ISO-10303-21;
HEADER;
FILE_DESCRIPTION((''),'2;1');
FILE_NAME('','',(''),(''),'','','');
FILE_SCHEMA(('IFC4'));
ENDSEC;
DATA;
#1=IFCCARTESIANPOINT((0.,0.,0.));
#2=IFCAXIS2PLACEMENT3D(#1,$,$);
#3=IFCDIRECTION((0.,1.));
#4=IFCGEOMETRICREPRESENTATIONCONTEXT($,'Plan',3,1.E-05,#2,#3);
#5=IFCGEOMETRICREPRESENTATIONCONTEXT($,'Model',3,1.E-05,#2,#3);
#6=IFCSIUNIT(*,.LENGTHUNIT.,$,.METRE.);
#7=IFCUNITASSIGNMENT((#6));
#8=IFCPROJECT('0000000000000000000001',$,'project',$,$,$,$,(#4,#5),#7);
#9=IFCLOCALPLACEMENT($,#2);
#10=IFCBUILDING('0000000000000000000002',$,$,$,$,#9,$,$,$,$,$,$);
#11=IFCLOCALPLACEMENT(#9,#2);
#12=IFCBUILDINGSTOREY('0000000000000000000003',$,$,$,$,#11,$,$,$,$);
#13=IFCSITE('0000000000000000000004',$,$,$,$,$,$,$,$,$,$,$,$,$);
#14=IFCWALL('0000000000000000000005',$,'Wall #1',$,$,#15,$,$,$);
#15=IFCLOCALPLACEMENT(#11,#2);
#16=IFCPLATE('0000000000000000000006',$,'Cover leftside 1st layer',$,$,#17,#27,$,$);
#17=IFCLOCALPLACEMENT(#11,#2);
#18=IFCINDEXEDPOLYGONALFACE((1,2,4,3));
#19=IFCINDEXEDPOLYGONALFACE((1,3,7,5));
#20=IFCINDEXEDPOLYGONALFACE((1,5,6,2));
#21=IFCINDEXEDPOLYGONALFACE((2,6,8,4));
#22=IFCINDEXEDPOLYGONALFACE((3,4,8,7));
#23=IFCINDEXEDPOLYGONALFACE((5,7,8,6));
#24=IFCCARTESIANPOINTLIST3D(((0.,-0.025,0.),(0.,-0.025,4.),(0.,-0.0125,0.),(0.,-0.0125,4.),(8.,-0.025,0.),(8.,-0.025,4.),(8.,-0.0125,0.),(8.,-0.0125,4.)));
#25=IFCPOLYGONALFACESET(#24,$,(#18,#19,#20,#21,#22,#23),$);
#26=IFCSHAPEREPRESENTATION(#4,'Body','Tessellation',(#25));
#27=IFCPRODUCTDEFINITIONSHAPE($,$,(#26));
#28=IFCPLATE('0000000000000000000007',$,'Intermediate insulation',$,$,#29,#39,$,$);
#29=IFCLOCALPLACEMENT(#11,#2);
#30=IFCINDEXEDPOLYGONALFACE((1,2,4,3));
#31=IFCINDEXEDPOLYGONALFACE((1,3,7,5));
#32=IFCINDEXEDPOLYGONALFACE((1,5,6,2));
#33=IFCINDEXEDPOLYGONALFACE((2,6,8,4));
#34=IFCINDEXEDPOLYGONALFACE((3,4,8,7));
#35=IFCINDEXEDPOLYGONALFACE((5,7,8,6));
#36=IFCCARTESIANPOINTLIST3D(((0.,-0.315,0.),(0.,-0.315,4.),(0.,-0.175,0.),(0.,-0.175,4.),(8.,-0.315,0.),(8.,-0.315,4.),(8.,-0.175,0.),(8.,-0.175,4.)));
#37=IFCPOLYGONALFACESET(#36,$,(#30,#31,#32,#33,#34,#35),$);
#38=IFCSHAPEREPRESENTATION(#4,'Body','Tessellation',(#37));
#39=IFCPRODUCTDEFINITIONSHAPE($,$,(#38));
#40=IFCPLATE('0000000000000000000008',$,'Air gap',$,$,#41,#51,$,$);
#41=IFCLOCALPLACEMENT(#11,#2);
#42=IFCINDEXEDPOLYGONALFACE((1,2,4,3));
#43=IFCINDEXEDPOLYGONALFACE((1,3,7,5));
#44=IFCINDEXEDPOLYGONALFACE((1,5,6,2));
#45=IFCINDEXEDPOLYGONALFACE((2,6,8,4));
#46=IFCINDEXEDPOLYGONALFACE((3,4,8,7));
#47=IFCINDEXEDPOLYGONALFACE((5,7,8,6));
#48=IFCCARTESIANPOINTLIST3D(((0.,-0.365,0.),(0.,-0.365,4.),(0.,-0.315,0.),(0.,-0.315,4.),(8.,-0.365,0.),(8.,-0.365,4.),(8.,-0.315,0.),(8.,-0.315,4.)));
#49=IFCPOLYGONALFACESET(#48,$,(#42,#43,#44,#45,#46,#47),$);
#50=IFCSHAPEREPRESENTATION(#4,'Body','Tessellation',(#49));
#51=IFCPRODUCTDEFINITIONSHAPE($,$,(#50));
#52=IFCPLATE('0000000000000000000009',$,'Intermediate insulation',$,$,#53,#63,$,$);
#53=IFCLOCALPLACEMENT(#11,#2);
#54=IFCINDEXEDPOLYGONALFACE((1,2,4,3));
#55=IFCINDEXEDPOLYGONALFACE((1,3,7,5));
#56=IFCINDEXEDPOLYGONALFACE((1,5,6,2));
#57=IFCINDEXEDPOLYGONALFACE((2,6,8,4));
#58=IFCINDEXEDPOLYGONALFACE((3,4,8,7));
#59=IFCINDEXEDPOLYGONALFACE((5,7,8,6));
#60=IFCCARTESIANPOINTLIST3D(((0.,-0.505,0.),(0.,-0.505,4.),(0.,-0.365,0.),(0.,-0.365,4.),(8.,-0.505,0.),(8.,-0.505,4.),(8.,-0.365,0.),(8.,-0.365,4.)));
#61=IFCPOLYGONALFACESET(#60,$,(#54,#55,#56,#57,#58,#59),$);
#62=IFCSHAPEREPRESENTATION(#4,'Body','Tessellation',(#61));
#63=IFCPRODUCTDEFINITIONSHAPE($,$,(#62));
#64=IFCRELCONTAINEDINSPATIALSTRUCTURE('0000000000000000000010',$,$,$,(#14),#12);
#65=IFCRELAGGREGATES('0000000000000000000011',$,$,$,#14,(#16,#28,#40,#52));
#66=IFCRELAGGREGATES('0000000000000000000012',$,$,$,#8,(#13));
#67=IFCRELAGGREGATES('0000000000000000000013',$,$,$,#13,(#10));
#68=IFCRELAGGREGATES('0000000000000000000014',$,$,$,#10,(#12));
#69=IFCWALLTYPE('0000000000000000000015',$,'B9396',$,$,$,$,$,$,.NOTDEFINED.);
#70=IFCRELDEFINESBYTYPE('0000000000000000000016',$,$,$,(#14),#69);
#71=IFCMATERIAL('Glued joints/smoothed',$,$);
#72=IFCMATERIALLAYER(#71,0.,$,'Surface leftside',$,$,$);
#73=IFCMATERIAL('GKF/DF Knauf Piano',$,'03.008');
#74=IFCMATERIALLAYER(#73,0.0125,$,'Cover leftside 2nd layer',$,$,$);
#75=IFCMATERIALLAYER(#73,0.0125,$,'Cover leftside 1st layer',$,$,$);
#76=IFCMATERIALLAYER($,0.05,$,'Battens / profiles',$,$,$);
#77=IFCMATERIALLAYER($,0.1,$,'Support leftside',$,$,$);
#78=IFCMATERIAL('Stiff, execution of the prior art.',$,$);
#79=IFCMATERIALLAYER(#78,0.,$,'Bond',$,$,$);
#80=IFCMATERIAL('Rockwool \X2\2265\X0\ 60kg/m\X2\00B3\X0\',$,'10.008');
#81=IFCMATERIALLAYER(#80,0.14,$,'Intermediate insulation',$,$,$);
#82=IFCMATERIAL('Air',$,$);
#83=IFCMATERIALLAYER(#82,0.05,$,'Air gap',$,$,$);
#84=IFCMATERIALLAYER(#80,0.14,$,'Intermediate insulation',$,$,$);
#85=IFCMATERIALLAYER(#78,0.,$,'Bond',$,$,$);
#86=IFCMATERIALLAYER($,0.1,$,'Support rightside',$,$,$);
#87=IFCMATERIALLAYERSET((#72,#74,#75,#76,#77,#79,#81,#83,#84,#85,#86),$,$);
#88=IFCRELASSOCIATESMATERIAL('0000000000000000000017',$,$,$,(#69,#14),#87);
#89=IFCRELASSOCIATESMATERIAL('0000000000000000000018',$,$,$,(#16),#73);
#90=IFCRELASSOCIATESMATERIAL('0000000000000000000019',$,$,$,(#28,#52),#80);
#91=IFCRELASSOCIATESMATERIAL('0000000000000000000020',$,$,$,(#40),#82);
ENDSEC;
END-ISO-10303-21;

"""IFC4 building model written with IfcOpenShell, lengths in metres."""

from ifc_helpers import new_model, si_unit, direction, frame, frame_2d, origin, place, context, project, spatial, rectangle, extrude, material, layer, layer_set, type_object, element, aggregate, save


model = new_model("IFC4")

# Units and contexts
plan_context = context("Plan", 3, precision=1e-05, world=origin(), true_north=direction((0.0, 1.0)))
model_context = context("Model", 3, precision=1e-05, world=origin(), true_north=direction((0.0, 1.0)))
ifc_project = project(units=[si_unit("LENGTHUNIT", "METRE")], contexts=[plan_context, model_context])

# Site, building, storey
site = spatial("IfcSite", under=ifc_project)
building_placement = place(None, origin())
building = spatial("IfcBuilding", under=site, at=building_placement)
storey_placement = place(building_placement, origin())
storey = spatial("IfcBuildingStorey", under=building, at=storey_placement)

# Wall, plates
ifc_material_1 = material(Name="Glued joints/smoothed")
ifc_layer_1 = layer(ifc_material_1, 0.0, Name="Surface leftside")
ifc_material_2 = material(Name="GKF/DF Knauf Piano", Category="03.008")
ifc_layer_2 = layer(ifc_material_2, 0.0125, Name="Cover leftside 2nd layer")
ifc_layer_3 = layer(ifc_material_2, 0.0125, Name="Cover leftside 1st layer")
ifc_layer_4 = layer(None, 0.05, Name="Battens / profiles")
ifc_layer_5 = layer(None, 0.1, Name="Support leftside")
ifc_material_3 = material(Name="Stiff, execution of the prior art.")
ifc_layer_6 = layer(ifc_material_3, 0.0, Name="Bond")
ifc_material_4 = material(Name="Rockwool ≥ 60kg/m³", Category="10.008")
ifc_layer_7 = layer(ifc_material_4, 0.14, Name="Intermediate insulation")
ifc_material_5 = material(Name="Air")
ifc_layer_8 = layer(ifc_material_5, 0.05, Name="Air gap")
ifc_layer_9 = layer(ifc_material_4, 0.14, Name="Intermediate insulation")
ifc_layer_10 = layer(ifc_material_3, 0.0, Name="Bond")
ifc_layer_11 = layer(None, 0.1, Name="Support rightside")
ifc_layer_set = layer_set([ifc_layer_1, ifc_layer_2, ifc_layer_3, ifc_layer_4, ifc_layer_5, ifc_layer_6, ifc_layer_7, ifc_layer_8, ifc_layer_9, ifc_layer_10, ifc_layer_11])
wall_type = type_object("IfcWallType", Name="B9396", PredefinedType="NOTDEFINED", material=ifc_layer_set)
wall_placement = place(None, frame((0.0, 0.0, 0.0), z_axis=(0.0, -1.0, 0.0), x_axis=(1.0, 0.0, 0.0)))
wall = element("IfcWall", 1, at=wall_placement, inside=storey, type_object=wall_type, material=ifc_layer_set, Name="Wall #1")
plate_1_placement = place(wall_placement, origin())
plate_1 = element("IfcPlate", 2, at=plate_1_placement, material=ifc_material_2, Name="Cover leftside 1st layer", context=plan_context, shape_type="SweptSolid", body=[
    extrude(rectangle(XDim=8.0, YDim=4.0, at=frame_2d((4.0, 2.0), x_axis=(1.0, 0.0))), frame((0.0, 0.0, 0.0125), z_axis=(0.0, 0.0, 1.0), x_axis=(1.0, 0.0, 0.0)), (0.0, 0.0, 1.0), 0.0125),
])
plate_2_placement = place(wall_placement, origin())
plate_2 = element("IfcPlate", 3, at=plate_2_placement, material=ifc_material_4, Name="Intermediate insulation", context=plan_context, shape_type="SweptSolid", body=[
    extrude(rectangle(XDim=8.0, YDim=4.0, at=frame_2d((4.0, 2.0), x_axis=(1.0, 0.0))), frame((0.0, 0.0, 0.175), z_axis=(0.0, 0.0, 1.0), x_axis=(1.0, 0.0, 0.0)), (0.0, 0.0, 1.0), 0.14),
])
plate_3_placement = place(wall_placement, origin())
plate_3 = element("IfcPlate", 4, at=plate_3_placement, material=ifc_material_5, Name="Air gap", context=plan_context, shape_type="SweptSolid", body=[
    extrude(rectangle(XDim=8.0, YDim=4.0, at=frame_2d((4.0, 2.0), x_axis=(1.0, 0.0))), frame((0.0, 0.0, 0.315), z_axis=(0.0, 0.0, 1.0), x_axis=(1.0, 0.0, 0.0)), (0.0, 0.0, 1.0), 0.05),
])
plate_4_placement = place(wall_placement, origin())
plate_4 = element("IfcPlate", 5, at=plate_4_placement, material=ifc_material_4, Name="Intermediate insulation", context=plan_context, shape_type="SweptSolid", body=[
    extrude(rectangle(XDim=8.0, YDim=4.0, at=frame_2d((4.0, 2.0), x_axis=(1.0, 0.0))), frame((0.0, 0.0, 0.365), z_axis=(0.0, 0.0, 1.0), x_axis=(1.0, 0.0, 0.0)), (0.0, 0.0, 1.0), 0.14),
])
aggregate(wall, [plate_1, plate_2, plate_3, plate_4])

save(model, "model.ifc")
